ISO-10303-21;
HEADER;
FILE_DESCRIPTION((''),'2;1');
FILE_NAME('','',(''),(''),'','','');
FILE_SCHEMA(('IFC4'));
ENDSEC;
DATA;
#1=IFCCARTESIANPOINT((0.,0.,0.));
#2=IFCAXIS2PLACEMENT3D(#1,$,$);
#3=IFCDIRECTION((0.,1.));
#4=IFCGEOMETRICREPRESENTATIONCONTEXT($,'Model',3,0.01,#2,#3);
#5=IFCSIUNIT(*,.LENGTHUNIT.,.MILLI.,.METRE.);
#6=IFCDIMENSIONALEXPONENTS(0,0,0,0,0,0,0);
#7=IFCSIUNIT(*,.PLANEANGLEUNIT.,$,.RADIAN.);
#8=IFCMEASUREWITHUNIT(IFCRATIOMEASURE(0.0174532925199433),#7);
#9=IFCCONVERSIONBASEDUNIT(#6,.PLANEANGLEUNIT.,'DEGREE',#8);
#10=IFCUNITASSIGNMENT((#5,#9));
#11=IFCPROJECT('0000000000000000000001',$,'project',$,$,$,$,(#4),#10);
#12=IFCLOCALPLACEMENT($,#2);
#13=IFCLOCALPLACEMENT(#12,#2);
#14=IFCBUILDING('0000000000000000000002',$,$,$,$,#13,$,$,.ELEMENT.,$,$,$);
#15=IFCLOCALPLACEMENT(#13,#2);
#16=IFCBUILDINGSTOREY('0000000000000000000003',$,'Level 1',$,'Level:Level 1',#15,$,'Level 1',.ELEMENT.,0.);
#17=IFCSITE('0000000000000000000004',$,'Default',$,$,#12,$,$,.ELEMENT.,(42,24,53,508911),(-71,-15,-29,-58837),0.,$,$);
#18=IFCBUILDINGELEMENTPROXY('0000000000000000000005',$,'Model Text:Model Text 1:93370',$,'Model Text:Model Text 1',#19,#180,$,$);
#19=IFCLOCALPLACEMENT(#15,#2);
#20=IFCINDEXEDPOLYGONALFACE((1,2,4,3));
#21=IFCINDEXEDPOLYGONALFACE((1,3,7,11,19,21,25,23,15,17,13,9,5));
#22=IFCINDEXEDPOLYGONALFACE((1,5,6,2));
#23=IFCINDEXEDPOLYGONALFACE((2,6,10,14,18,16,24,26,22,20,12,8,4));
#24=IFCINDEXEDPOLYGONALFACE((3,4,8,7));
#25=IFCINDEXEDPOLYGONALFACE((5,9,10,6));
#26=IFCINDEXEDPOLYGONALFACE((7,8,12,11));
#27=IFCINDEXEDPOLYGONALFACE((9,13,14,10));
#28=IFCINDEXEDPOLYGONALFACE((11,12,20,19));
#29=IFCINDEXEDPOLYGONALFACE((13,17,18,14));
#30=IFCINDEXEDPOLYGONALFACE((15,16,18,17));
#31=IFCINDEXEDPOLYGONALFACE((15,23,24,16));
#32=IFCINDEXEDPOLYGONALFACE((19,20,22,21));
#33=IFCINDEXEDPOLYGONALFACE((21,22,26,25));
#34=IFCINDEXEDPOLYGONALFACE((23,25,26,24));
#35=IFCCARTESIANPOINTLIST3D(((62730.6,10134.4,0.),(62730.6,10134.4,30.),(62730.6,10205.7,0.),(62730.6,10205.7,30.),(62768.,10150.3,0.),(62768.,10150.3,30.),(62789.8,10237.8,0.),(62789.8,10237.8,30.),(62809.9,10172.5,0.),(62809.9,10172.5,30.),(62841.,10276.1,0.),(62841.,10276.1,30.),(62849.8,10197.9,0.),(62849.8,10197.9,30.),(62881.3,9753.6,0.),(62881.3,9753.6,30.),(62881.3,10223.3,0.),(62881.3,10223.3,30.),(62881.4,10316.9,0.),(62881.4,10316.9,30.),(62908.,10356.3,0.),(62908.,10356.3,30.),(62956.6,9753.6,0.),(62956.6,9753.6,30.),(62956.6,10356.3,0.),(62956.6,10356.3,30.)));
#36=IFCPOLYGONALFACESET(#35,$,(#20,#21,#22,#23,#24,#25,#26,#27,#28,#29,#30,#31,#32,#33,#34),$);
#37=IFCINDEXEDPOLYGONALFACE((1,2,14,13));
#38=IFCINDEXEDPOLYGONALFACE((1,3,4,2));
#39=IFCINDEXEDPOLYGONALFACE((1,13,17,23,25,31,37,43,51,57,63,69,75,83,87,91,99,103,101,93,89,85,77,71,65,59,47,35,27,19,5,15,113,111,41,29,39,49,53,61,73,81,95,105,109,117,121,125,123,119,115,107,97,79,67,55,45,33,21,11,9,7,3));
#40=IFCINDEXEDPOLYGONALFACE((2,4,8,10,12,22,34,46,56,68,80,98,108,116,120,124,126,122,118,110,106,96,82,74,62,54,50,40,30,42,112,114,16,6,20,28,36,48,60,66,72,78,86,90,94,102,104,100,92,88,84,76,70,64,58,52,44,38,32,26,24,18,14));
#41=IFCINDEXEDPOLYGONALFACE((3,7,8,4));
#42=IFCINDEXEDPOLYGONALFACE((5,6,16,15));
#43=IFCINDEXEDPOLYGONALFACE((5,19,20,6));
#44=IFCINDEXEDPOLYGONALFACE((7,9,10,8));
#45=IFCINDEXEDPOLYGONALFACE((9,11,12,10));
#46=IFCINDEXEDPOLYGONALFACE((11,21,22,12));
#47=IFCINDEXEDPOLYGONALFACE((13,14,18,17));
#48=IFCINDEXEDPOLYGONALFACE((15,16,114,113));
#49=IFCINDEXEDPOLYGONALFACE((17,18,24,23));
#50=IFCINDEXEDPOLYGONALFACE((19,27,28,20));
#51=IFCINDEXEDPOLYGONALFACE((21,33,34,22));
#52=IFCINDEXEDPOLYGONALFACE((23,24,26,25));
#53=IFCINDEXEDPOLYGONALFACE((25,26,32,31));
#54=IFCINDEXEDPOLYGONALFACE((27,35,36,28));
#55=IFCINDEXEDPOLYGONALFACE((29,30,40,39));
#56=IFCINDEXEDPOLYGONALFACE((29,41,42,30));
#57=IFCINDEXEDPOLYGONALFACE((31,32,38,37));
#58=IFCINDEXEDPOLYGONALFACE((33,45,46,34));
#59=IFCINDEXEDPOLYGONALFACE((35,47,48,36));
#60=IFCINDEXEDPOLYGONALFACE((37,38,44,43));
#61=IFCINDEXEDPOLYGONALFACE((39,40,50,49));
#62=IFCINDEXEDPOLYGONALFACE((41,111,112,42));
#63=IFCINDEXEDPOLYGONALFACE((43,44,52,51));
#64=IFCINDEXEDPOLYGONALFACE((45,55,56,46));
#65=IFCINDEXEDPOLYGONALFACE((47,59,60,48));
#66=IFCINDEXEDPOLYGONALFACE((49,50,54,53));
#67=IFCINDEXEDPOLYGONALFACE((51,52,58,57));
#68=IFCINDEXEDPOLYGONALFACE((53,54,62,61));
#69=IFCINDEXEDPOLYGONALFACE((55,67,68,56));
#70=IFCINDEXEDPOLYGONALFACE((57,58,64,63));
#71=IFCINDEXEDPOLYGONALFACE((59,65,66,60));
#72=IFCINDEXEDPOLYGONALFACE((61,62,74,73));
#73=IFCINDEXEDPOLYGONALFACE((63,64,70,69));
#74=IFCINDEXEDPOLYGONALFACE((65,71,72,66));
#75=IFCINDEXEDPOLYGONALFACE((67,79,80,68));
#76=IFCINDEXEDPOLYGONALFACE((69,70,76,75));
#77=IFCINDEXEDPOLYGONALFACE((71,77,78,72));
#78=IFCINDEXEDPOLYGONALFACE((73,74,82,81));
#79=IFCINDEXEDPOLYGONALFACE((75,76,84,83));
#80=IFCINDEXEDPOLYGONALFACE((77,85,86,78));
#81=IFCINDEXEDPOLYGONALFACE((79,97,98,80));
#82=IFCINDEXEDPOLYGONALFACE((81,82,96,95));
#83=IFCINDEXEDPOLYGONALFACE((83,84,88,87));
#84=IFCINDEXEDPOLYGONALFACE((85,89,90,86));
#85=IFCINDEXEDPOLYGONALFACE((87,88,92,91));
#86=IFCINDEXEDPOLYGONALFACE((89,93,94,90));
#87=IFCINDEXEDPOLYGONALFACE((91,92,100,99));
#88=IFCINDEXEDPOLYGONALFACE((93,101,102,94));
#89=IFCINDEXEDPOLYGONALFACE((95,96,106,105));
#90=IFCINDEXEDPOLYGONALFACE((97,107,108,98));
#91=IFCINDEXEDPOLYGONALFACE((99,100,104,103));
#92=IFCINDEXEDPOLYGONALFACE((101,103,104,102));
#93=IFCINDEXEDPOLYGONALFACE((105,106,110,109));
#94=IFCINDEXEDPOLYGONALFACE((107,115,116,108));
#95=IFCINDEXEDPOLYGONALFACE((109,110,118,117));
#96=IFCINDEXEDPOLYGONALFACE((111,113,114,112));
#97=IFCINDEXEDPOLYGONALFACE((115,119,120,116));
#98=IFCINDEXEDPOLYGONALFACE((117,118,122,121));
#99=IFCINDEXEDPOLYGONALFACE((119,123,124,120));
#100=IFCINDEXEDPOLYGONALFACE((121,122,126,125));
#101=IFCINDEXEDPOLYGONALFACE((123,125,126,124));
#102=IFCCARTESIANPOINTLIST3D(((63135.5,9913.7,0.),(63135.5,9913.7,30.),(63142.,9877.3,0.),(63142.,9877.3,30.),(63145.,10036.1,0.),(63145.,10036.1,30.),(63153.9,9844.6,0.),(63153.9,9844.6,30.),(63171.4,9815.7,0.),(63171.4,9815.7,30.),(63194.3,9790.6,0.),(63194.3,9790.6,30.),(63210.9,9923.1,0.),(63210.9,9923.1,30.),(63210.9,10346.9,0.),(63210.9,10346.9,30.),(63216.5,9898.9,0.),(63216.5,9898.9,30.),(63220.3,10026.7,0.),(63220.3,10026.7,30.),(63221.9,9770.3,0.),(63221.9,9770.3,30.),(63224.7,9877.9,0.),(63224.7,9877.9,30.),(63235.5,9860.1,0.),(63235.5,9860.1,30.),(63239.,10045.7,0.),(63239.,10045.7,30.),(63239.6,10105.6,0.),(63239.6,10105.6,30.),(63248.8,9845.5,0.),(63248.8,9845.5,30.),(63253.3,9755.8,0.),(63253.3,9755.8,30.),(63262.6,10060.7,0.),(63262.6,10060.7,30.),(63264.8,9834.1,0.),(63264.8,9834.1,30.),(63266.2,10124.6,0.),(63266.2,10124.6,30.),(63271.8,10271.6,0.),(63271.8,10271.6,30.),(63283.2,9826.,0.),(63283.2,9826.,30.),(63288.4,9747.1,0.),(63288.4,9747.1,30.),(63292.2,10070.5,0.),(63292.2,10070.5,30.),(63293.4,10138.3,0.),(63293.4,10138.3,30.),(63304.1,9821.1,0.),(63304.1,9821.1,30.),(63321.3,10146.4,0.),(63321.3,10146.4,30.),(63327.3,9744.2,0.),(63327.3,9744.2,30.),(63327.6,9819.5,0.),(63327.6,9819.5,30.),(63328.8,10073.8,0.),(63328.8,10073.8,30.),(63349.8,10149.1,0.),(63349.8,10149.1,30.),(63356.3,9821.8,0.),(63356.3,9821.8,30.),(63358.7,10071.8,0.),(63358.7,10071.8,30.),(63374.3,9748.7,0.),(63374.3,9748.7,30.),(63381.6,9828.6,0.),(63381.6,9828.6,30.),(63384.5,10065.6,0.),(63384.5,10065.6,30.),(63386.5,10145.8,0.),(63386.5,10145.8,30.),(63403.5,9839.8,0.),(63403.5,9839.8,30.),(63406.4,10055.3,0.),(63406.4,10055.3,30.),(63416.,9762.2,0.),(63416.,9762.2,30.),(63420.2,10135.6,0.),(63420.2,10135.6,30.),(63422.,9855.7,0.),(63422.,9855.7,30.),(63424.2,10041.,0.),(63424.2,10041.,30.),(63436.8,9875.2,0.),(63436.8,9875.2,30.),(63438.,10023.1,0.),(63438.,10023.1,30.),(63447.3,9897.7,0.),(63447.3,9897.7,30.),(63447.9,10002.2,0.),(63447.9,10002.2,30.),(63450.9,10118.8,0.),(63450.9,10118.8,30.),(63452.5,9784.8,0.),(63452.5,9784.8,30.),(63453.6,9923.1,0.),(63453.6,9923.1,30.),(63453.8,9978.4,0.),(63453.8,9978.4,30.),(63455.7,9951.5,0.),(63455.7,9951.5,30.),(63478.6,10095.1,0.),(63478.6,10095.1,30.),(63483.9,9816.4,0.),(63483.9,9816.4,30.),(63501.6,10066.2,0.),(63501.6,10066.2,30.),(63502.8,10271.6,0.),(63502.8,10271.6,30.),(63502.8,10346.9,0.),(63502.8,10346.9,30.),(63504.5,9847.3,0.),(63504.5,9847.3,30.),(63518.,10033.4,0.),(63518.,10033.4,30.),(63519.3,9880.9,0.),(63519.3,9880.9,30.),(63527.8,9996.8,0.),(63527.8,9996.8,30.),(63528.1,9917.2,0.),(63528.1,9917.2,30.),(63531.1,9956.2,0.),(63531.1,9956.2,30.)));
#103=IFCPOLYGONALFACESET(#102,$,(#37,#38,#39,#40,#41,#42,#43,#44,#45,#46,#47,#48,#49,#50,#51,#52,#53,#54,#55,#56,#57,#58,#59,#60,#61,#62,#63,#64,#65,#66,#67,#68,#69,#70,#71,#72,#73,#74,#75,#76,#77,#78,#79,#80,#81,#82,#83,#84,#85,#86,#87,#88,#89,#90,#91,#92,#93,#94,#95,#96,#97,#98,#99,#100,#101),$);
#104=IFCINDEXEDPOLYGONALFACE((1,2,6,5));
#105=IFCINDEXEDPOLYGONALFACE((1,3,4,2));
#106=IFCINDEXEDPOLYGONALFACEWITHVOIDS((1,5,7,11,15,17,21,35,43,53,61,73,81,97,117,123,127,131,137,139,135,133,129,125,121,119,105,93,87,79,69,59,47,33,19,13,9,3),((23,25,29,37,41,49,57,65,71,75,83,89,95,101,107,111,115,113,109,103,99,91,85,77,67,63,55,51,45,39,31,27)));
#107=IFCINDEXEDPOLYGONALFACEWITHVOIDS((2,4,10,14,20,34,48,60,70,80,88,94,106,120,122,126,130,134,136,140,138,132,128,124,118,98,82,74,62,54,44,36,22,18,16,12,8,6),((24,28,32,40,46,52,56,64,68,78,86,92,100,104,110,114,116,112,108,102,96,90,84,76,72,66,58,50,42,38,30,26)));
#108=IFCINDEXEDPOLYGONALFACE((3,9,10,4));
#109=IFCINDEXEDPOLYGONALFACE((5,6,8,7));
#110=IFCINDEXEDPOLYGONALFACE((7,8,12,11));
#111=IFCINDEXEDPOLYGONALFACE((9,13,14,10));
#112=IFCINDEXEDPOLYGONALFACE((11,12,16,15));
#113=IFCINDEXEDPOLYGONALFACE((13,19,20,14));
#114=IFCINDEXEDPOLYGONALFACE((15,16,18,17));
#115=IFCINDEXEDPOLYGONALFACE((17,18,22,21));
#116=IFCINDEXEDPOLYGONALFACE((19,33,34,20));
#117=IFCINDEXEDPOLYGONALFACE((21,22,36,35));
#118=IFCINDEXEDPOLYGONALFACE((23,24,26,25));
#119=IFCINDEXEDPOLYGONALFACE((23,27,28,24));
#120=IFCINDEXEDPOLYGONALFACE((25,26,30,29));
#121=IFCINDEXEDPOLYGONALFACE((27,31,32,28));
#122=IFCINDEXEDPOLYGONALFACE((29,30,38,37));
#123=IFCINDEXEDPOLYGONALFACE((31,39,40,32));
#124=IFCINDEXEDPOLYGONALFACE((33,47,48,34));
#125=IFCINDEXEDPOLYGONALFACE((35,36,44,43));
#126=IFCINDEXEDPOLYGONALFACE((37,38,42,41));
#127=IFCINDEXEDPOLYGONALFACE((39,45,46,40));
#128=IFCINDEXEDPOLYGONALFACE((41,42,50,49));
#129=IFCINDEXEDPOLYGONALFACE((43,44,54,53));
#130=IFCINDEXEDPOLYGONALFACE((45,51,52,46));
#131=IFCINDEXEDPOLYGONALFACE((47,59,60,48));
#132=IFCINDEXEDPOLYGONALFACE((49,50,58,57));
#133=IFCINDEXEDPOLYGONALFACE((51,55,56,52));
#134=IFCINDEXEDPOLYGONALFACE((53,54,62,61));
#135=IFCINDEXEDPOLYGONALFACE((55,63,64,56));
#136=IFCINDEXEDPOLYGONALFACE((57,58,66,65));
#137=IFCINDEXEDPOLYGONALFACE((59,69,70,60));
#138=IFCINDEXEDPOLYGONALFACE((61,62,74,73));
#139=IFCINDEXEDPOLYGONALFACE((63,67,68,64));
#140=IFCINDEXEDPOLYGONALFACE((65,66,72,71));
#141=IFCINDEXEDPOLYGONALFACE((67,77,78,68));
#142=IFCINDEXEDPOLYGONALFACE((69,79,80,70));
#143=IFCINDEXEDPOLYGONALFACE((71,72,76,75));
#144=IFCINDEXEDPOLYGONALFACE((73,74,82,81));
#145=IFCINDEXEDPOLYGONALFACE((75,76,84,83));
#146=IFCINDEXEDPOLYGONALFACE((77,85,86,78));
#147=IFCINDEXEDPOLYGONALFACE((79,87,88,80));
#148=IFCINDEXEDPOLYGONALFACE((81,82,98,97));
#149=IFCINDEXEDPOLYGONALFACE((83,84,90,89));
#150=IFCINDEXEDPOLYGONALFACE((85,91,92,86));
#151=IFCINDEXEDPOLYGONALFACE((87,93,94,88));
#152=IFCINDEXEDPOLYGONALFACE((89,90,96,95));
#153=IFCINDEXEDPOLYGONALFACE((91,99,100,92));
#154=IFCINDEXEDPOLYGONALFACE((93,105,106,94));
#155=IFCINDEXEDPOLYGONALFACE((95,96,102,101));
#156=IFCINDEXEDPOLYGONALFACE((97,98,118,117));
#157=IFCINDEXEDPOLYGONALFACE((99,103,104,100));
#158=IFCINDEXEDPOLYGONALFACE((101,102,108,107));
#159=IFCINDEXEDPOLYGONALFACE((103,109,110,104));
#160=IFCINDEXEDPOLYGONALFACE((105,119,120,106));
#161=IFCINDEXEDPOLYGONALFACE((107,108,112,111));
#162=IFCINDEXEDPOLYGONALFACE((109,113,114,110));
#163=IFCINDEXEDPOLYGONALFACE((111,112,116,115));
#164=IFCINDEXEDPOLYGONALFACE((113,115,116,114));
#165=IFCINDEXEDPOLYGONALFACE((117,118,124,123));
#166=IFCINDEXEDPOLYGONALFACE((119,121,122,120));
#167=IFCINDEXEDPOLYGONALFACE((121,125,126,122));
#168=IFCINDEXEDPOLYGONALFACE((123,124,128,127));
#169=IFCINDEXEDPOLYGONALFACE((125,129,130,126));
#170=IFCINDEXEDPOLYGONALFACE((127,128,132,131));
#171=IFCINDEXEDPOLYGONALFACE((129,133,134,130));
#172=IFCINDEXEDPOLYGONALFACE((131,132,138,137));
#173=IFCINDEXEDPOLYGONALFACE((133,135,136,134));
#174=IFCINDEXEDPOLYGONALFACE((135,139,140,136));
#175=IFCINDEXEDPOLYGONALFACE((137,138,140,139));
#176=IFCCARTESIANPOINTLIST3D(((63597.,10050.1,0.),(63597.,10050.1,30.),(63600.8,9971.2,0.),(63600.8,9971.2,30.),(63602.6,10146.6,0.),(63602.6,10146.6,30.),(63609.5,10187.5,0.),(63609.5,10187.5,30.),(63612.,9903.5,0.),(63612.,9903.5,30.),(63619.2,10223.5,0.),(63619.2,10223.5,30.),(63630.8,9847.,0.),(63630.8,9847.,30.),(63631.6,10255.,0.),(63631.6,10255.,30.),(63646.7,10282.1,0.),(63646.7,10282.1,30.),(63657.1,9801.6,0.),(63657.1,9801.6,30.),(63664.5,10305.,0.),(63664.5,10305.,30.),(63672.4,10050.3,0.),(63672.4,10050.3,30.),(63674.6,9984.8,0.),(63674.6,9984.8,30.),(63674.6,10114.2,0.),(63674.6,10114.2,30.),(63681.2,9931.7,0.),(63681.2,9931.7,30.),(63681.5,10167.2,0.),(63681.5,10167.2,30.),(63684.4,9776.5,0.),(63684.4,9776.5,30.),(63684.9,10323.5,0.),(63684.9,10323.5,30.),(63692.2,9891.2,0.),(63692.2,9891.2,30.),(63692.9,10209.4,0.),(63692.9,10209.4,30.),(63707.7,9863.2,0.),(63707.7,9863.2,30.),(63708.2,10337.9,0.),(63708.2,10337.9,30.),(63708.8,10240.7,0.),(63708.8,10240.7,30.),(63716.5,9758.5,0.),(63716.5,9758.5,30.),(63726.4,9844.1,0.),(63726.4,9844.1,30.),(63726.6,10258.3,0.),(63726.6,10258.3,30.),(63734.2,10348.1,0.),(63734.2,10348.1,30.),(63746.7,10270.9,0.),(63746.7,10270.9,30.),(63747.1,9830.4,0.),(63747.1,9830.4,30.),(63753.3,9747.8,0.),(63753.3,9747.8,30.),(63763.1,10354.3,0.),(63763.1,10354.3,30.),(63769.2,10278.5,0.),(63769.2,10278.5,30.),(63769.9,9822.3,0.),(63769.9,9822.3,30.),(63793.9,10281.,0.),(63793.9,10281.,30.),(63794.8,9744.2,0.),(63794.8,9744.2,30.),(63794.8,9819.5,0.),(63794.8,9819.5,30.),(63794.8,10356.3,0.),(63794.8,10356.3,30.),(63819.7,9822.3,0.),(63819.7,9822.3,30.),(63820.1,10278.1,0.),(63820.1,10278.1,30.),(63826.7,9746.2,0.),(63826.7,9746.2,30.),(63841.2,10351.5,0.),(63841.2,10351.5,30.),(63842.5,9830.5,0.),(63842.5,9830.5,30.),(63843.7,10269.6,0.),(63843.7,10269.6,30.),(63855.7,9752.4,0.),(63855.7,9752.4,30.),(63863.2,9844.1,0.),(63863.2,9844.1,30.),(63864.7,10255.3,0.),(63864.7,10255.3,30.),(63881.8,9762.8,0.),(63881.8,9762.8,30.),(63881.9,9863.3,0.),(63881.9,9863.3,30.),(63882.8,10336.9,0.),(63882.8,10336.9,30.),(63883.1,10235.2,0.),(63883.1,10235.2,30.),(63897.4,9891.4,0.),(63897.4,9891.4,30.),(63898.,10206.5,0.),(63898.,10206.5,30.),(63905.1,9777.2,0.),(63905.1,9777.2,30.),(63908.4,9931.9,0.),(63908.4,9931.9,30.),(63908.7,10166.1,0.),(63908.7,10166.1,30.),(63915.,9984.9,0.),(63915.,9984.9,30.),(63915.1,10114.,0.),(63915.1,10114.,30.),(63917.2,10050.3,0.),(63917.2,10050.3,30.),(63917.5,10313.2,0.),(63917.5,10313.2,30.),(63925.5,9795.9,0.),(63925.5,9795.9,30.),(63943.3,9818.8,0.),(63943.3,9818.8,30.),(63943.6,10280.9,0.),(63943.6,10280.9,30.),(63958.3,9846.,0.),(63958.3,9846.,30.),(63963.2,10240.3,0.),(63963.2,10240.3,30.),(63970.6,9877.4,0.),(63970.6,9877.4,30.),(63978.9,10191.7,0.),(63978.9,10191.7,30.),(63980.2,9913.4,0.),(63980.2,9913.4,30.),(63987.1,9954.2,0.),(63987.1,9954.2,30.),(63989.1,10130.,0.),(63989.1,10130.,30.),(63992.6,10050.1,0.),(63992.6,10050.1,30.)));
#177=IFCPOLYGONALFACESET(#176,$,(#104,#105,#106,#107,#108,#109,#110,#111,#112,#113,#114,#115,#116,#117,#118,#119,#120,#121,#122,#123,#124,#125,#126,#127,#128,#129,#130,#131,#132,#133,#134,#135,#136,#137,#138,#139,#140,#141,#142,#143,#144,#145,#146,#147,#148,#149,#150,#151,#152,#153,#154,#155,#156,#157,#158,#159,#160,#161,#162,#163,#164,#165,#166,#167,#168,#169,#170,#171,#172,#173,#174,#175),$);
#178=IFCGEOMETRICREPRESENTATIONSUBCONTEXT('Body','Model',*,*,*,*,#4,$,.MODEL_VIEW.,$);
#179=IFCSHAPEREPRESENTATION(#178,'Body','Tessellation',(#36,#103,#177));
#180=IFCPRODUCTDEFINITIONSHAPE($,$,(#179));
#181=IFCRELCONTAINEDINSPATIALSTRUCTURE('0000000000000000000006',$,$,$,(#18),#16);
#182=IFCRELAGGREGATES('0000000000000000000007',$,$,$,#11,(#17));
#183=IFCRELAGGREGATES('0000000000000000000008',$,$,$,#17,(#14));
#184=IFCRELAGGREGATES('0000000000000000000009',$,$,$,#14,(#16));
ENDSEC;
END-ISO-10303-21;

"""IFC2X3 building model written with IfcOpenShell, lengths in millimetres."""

from ifc_helpers import new_model, entity, si_unit, converted_unit, direction, frame, origin, place, context, subcontext, project, spatial, polyline, outline, extrude, element, save


model = new_model("IFC2X3")

# Units and contexts
model_context = context("Model", 3, precision=0.01, world=origin(), true_north=direction((0.0, 1.0)))
body_context = subcontext(model_context, "Body", "Model", "MODEL_VIEW")
ifc_project = project(units=[si_unit("LENGTHUNIT", "METRE", prefix="MILLI"), converted_unit("PLANEANGLEUNIT", "DEGREE", entity("IfcRatioMeasure", 0.0174532925199433), si_unit("PLANEANGLEUNIT", "RADIAN"), dimensions=[0, 0, 0, 0, 0, 0, 0])], contexts=[model_context])

# Site, building, storey
site_placement = place(None, origin())
site = spatial("IfcSite", under=ifc_project, at=site_placement, Name="Default", CompositionType="ELEMENT", RefLatitude=(42, 24, 53, 508911), RefLongitude=(-71, -15, -29, -58837), RefElevation=0.0)
building_placement = place(site_placement, origin())
building = spatial("IfcBuilding", under=site, at=building_placement, CompositionType="ELEMENT")
storey_placement = place(building_placement, origin())
storey = spatial("IfcBuildingStorey", under=building, at=storey_placement, Name="Level 1", ObjectType="Level:Level 1", LongName="Level 1", CompositionType="ELEMENT", Elevation=0.0)

# Building element proxy
proxy_1_placement = place(storey_placement, origin())
element("IfcBuildingElementProxy", 1, at=proxy_1_placement, inside=storey, Name="Model Text:Model Text 1:93370", ObjectType="Model Text:Model Text 1", context=body_context, shape_type="SweptSolid", body=[
    extrude(outline(polyline([(-410.6, -111.6), (192.1, -111.6), (192.1, -63.1), (152.7, -36.4), (111.9, 4.0), (73.6, 55.2), (41.4, 114.4), (-29.8, 114.4), (-13.9, 77.0), (8.3, 35.1), (33.7, -4.8), (59.1, -36.3), (-410.6, -36.3), (-410.6, -111.6)])), frame((62845.0, 10164.2, 0.0), z_axis=(0.0, 0.0, 1.0), x_axis=(0.0, 1.0, 0.0)), (0.0, 0.0, 1.0), 30.0),
    extrude(outline(polyline([(12.1, -219.3), (49.1, -219.3), (83.4, -213.2), (114.8, -201.1), (143.5, -182.8), (168.3, -159.2), (188.1, -130.8), (202.8, -97.8), (212.4, -60.0), (216.1, -12.9), (210.0, 30.5), (194.1, 70.4), (168.4, 106.8), (141.6, 132.5), (111.1, 152.9), (76.9, 167.9), (39.0, 177.6), (-1.5, 181.4), (-39.3, 178.1), (-74.4, 167.6), (-106.9, 150.1), (-135.0, 126.9), (-157.0, 99.6), (-172.8, 68.1), (-182.5, 32.6), (-184.8, 4.0), (-181.6, -24.8), (-172.9, -54.0), (-158.8, -83.5), (-316.6, -22.9), (-276.5, 204.6), (-350.7, 217.7), (-401.4, -69.8), (-106.8, -188.8), (-84.5, -116.2), (-99.9, -94.5), (-110.6, -68.6), (-115.1, -37.8), (-112.0, -1.2), (-104.8, 27.9), (-94.2, 52.3), (-80.3, 72.0), (-63.1, 87.0), (-43.0, 97.5), (-20.8, 103.6), (3.8, 105.3), (30.5, 102.6), (58.1, 95.6), (82.1, 84.9), (102.4, 70.6), (119.1, 52.7), (131.4, 31.7), (138.7, 8.2), (141.0, -17.9), (138.2, -46.6), (132.6, -69.4), (124.1, -89.2), (112.9, -105.9), (99.0, -119.6), (82.3, -130.2), (62.9, -137.7), (40.8, -142.2), (15.9, -143.5), (12.1, -219.3)])), frame((63349.4, 9963.8, 0.0), z_axis=(0.0, 0.0, 1.0), x_axis=(0.173842, -0.984774, 0.0)), (0.0, 0.0, 1.0), 30.0),
    extrude(outline(polyline([(-10.6, -198.7), (68.3, -198.7), (136.5, -190.7), (193.9, -174.7), (240.5, -150.6), (266.9, -124.4), (286.3, -93.2), (298.8, -57.0), (304.3, -15.7), (303.8, 16.2), (299.0, 45.5), (289.9, 72.1), (276.6, 96.0), (258.9, 117.3), (236.9, 136.2), (210.4, 152.5), (179.6, 166.3), (144.1, 177.6), (103.7, 186.3), (8.2, 196.4), (-71.8, 196.7), (-134.0, 189.4), (-183.3, 176.1), (-224.7, 158.4), (-258.2, 133.9), (-283.5, 100.3), (-300.1, 59.5), (-307.1, 13.4), (-306.6, -18.4), (-301.8, -47.5), (-292.8, -74.0), (-279.6, -97.9), (-262.0, -119.2), (-240.0, -138.1), (-213.6, -154.5), (-182.8, -168.4), (-147.3, -179.8), (-106.7, -188.6), (-10.6, -198.7)]), holes=[polyline([(-7.2, -123.5), (-71.0, -118.2), (-123.6, -108.8), (-165.2, -95.4), (-195.7, -78.0), (-212.4, -59.4), (-224.1, -38.7), (-230.6, -15.9), (-231.9, 8.9), (-227.8, 35.0), (-218.1, 58.1), (-202.8, 78.4), (-182.0, 95.8), (-152.6, 109.4), (-111.7, 118.1), (-59.4, 122.0), (4.4, 121.1), (69.6, 115.8), (122.2, 106.7), (162.2, 93.7), (189.5, 77.0), (207.7, 57.4), (220.4, 36.0), (227.5, 12.8), (229.1, -12.1), (225.2, -36.8), (215.9, -59.2), (201.3, -79.3), (181.4, -97.1), (152.6, -111.2), (111.6, -120.3), (58.3, -124.4), (-7.2, -123.5)])]), frame((63796.0, 10048.9, 0.0), z_axis=(0.0, 0.0, 1.0), x_axis=(0.047515, -0.998871, 0.0)), (0.0, 0.0, 1.0), 30.0),
])

save(model, "model.ifc")
